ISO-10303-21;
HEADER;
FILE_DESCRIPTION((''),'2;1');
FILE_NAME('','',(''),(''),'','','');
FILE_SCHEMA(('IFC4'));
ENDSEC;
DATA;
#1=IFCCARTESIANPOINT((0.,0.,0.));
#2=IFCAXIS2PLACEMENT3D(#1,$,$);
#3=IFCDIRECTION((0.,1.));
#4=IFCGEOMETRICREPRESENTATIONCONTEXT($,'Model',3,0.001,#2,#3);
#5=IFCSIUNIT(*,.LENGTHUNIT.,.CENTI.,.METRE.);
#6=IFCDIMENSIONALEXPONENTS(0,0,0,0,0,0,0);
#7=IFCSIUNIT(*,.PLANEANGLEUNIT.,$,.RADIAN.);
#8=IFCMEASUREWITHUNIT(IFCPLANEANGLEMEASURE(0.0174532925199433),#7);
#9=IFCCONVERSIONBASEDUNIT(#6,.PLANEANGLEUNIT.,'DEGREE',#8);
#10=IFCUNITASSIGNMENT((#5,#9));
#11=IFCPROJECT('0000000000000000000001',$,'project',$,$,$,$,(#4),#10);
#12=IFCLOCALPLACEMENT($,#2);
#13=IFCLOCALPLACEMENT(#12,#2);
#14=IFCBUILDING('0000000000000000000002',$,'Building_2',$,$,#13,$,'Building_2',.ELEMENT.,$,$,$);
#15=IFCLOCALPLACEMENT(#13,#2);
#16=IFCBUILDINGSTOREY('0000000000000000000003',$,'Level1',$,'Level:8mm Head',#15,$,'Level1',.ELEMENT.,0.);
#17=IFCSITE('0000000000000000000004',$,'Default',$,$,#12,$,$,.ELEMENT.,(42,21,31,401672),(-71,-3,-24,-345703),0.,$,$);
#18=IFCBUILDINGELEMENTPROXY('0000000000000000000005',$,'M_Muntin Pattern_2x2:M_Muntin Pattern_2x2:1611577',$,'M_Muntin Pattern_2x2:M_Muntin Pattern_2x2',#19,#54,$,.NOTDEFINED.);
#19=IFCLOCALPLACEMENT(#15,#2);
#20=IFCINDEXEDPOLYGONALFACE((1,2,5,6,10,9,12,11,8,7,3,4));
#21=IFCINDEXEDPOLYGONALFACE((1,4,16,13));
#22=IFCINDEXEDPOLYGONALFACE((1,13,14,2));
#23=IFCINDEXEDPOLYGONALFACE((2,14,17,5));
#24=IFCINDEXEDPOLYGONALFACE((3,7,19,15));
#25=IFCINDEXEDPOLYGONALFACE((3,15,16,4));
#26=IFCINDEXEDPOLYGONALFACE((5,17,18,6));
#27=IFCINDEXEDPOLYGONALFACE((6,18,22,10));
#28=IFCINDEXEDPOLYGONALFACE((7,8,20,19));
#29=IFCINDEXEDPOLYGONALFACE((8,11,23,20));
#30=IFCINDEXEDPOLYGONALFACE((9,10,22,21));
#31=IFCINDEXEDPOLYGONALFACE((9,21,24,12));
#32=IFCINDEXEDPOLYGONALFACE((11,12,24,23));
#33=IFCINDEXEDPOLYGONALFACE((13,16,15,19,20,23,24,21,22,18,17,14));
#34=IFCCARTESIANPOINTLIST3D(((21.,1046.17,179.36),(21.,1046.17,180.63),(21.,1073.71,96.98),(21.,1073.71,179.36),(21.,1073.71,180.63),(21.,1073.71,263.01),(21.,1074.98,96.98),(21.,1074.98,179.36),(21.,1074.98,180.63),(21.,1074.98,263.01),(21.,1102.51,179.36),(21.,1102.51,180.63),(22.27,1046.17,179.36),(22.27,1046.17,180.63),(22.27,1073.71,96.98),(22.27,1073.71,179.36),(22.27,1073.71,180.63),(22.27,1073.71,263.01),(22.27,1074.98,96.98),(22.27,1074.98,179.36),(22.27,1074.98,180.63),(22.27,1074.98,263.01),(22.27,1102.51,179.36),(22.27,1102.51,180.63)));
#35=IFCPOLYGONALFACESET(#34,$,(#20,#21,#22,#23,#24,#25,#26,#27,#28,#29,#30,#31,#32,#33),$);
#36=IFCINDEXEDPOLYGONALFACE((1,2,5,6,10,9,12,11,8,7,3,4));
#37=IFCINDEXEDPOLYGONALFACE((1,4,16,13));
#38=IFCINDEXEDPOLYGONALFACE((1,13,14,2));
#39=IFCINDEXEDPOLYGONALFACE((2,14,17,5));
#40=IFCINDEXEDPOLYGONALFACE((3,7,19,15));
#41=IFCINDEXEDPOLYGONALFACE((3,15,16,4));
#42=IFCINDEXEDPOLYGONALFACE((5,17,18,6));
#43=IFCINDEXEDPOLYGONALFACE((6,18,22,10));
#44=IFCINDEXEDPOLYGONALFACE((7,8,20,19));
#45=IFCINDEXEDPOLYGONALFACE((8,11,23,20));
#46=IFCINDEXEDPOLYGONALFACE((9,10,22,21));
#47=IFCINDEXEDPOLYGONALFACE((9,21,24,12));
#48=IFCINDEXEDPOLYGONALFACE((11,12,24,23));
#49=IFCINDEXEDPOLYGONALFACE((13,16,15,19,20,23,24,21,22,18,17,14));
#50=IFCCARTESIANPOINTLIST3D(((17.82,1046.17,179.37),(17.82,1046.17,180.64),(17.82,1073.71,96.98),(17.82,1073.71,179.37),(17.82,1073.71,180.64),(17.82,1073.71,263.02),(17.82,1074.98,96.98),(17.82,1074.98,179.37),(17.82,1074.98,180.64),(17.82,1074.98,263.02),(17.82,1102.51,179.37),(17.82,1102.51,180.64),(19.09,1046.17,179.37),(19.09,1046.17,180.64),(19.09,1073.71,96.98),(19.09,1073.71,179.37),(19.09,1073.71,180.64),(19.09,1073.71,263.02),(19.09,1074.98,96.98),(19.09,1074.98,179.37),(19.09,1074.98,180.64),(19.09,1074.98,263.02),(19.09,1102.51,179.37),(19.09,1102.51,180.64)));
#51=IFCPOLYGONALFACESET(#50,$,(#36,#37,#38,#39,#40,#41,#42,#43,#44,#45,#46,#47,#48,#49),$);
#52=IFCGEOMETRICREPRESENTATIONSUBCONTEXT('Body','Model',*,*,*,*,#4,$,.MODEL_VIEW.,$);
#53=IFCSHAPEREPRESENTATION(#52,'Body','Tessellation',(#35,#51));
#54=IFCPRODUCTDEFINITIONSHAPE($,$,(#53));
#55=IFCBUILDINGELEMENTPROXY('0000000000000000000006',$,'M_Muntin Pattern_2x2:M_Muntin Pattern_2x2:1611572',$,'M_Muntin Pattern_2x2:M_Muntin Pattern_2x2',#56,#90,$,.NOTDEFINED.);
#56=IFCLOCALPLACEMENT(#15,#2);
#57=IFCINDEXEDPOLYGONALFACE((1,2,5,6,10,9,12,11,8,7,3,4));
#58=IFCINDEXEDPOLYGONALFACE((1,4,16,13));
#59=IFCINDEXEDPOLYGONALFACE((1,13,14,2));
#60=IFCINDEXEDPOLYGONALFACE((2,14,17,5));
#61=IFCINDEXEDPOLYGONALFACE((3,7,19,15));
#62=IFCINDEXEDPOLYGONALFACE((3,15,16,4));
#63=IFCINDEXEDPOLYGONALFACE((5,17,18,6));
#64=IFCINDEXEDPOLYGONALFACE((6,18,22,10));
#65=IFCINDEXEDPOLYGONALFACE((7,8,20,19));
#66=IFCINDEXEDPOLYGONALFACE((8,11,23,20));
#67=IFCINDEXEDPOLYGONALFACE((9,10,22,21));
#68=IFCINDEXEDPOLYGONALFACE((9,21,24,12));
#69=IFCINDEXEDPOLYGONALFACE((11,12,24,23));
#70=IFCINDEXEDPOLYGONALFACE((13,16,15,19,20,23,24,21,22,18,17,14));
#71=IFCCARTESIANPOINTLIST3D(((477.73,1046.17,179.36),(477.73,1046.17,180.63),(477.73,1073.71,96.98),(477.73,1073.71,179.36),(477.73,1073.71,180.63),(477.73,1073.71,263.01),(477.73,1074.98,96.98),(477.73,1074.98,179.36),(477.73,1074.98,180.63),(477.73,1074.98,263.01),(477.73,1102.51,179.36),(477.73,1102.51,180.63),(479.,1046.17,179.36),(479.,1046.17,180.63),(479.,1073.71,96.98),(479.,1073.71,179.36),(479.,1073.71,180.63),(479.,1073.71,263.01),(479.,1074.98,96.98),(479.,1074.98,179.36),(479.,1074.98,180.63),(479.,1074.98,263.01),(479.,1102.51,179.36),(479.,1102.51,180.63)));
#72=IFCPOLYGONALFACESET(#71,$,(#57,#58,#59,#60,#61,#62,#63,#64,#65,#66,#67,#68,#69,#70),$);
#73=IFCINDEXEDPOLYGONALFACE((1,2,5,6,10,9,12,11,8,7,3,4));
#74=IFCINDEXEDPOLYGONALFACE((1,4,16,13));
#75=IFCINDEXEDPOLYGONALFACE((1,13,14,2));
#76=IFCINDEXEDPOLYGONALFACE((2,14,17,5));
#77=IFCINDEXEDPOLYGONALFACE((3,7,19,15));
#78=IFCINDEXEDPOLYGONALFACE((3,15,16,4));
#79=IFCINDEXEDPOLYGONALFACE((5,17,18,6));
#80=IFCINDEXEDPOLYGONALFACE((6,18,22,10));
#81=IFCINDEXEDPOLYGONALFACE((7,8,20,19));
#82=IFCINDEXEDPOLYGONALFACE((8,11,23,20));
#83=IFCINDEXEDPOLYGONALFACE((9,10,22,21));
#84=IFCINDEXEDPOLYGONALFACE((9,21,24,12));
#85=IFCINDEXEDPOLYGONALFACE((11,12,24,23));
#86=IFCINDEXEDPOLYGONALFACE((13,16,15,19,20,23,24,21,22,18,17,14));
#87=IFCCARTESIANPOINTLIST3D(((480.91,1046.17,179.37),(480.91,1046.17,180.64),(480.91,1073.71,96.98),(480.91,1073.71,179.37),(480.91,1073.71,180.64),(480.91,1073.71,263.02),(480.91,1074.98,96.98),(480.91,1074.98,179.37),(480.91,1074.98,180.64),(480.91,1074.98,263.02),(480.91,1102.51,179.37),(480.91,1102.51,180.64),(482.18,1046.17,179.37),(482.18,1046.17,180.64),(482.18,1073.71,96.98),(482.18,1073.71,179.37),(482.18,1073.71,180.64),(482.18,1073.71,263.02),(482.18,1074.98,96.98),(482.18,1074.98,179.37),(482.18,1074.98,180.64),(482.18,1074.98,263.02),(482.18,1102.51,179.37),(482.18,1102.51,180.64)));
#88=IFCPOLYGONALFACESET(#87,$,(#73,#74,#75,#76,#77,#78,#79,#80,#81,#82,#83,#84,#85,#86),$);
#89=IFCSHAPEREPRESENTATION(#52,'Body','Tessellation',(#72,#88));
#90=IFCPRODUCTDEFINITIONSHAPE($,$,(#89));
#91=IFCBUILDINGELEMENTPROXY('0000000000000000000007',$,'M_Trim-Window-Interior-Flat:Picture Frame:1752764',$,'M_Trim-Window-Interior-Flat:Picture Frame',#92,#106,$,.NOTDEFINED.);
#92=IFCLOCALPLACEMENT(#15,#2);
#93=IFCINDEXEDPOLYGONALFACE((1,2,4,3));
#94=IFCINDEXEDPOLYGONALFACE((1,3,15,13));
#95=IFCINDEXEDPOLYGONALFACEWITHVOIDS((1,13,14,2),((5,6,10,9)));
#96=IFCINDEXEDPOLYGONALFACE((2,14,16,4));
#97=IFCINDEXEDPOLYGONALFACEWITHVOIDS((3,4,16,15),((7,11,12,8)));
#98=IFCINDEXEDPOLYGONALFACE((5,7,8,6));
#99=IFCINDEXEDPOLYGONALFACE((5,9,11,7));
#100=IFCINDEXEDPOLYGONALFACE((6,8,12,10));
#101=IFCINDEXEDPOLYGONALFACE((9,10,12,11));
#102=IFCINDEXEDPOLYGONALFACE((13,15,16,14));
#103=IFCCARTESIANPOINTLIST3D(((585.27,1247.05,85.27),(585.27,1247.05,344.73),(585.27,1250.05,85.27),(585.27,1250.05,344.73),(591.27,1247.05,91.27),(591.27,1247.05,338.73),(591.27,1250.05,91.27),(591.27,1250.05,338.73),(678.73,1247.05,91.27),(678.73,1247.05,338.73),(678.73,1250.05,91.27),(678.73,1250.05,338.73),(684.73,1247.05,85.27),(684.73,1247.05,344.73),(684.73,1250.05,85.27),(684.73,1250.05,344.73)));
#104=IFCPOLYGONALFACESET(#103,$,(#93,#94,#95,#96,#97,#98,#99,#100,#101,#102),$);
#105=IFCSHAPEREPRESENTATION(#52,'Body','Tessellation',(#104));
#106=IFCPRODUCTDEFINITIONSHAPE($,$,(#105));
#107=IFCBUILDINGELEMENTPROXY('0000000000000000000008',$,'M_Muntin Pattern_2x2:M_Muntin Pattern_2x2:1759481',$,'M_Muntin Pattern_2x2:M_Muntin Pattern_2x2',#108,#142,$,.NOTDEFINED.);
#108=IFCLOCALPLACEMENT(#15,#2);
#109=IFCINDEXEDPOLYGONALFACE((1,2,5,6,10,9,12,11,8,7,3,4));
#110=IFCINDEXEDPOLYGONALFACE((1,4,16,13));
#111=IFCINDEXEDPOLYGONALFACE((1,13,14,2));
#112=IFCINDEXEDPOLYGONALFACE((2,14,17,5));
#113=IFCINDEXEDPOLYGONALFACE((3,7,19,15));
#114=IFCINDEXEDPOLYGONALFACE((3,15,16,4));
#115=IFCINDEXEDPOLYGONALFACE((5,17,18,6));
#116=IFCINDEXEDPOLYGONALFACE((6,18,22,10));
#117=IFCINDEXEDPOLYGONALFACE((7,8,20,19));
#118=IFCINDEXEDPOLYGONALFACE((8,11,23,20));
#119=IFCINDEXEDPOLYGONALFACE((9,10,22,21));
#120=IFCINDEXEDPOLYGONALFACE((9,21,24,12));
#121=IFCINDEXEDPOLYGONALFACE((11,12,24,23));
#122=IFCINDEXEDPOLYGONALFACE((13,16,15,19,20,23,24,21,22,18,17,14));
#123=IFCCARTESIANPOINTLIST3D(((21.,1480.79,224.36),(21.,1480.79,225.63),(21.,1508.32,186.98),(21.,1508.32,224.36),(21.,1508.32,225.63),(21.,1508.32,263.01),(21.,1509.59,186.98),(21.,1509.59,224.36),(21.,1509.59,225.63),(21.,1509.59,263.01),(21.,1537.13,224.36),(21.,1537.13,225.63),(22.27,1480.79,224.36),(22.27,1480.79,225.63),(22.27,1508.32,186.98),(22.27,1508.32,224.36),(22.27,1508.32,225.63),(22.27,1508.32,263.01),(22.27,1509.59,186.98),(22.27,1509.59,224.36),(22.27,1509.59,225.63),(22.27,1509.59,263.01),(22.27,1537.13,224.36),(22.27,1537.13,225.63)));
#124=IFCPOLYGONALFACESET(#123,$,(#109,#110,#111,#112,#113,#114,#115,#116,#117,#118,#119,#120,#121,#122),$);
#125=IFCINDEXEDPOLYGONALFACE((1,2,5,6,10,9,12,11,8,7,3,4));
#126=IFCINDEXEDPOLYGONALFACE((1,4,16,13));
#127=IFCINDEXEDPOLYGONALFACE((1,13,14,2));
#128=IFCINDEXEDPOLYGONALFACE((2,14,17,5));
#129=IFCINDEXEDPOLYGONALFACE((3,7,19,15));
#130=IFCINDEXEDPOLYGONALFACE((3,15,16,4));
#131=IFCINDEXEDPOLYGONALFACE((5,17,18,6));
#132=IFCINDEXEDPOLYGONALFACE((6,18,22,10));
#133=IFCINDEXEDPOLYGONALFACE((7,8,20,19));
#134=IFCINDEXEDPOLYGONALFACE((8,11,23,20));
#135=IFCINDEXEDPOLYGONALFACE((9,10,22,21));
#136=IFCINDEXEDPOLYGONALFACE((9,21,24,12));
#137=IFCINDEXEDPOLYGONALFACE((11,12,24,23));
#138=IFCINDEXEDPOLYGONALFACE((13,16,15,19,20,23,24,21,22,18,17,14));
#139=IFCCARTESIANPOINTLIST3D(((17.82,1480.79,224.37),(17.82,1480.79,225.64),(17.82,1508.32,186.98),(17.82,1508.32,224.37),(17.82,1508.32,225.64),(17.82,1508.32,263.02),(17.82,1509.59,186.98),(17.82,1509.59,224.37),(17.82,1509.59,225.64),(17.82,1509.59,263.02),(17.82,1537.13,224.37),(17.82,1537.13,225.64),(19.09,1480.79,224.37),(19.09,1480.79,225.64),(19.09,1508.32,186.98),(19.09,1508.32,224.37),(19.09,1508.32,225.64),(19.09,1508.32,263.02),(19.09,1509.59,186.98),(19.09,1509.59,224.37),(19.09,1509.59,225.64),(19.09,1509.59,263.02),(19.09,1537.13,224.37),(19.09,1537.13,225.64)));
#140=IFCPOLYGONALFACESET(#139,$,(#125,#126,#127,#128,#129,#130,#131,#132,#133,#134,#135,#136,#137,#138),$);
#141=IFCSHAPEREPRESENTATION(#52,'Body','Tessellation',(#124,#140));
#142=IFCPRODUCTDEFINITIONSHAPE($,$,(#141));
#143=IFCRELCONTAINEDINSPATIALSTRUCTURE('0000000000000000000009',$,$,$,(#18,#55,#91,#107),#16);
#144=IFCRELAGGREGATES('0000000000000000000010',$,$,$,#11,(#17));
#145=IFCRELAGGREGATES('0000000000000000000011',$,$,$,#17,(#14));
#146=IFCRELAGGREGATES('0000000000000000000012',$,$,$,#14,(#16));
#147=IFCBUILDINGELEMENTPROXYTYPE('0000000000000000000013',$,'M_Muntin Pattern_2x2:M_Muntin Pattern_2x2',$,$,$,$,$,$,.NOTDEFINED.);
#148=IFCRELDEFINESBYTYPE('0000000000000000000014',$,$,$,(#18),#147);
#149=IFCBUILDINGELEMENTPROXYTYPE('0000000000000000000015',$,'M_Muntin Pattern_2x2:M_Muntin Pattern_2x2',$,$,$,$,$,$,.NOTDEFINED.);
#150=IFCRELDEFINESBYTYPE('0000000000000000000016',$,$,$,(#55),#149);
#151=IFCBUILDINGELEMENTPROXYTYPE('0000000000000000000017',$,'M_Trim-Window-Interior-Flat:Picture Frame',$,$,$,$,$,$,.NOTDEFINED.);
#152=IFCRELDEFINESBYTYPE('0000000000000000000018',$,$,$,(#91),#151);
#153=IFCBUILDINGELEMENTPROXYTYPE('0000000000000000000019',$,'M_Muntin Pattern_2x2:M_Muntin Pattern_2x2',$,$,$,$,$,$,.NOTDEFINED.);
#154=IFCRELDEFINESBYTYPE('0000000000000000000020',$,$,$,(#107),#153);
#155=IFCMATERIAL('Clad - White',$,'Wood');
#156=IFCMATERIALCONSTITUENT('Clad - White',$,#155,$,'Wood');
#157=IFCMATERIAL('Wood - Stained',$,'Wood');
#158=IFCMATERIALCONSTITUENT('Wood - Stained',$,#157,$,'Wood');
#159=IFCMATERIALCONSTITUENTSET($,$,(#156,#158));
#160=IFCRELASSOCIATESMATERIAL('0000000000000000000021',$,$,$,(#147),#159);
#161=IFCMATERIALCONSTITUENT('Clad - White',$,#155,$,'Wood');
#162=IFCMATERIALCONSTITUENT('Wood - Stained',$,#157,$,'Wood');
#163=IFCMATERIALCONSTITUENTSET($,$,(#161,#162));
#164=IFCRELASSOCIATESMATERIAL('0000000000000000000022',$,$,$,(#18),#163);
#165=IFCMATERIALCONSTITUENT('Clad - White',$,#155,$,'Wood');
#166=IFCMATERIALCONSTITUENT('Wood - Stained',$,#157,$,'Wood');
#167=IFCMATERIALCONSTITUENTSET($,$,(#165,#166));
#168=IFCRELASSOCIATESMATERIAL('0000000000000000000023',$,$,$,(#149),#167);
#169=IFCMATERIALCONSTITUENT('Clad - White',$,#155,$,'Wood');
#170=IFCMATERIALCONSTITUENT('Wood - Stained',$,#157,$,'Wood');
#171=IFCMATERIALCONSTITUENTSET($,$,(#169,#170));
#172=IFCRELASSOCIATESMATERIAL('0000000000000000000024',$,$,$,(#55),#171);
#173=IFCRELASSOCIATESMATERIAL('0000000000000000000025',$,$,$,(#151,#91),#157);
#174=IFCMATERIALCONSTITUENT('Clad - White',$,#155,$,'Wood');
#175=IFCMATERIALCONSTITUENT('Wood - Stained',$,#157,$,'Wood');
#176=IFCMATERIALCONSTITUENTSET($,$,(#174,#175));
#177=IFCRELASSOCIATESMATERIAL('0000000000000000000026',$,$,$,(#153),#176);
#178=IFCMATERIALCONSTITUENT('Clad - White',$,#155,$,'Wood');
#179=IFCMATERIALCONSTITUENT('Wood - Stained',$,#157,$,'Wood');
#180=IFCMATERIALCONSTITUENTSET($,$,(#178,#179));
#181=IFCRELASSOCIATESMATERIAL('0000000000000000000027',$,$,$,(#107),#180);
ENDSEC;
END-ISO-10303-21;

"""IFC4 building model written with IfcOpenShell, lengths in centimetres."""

from ifc_helpers import new_model, entity, si_unit, converted_unit, direction, frame, origin, place, context, subcontext, project, spatial, indexed_curve, outline, extrude, source, transform, mapped, material, constituent, constituent_set, type_object, type_shapes, element, save


model = new_model("IFC4")

# Units and contexts
model_context = context("Model", 3, precision=0.001, world=origin(), true_north=direction((0.0, 1.0)))
body_context = subcontext(model_context, "Body", "Model", "MODEL_VIEW")
ifc_project = project(units=[si_unit("LENGTHUNIT", "METRE", prefix="CENTI"), converted_unit("PLANEANGLEUNIT", "DEGREE", entity("IfcPlaneAngleMeasure", 0.0174532925199433), si_unit("PLANEANGLEUNIT", "RADIAN"), dimensions=[0, 0, 0, 0, 0, 0, 0])], contexts=[model_context])

# Site, building, storey
site_placement = place(None, origin())
site = spatial("IfcSite", under=ifc_project, at=site_placement, Name="Default", CompositionType="ELEMENT", RefLatitude=(42, 21, 31, 401672), RefLongitude=(-71, -3, -24, -345703), RefElevation=0.0)
building_placement = place(site_placement, origin())
building = spatial("IfcBuilding", under=site, at=building_placement, Name="Building_2", LongName="Building_2", CompositionType="ELEMENT")
storey_placement = place(building_placement, origin())
storey = spatial("IfcBuildingStorey", under=building, at=storey_placement, Name="Level1", ObjectType="Level:8mm Head", LongName="Level1", CompositionType="ELEMENT", Elevation=0.0)

# Building element proxies
ifc_material_1 = material(Name="Clad - White", Category="Wood")
ifc_constituent_1 = constituent(ifc_material_1, Name="Clad - White", Category="Wood")
ifc_material_2 = material(Name="Wood - Stained", Category="Wood")
ifc_constituent_2 = constituent(ifc_material_2, Name="Wood - Stained", Category="Wood")
ifc_constituent_set_1 = constituent_set(constituents=[ifc_constituent_1, ifc_constituent_2])
ifc_constituent_3 = constituent(ifc_material_1, Name="Clad - White", Category="Wood")
ifc_constituent_4 = constituent(ifc_material_2, Name="Wood - Stained", Category="Wood")
ifc_constituent_set_2 = constituent_set(constituents=[ifc_constituent_3, ifc_constituent_4])
building_element_proxy_type_1 = type_object("IfcBuildingElementProxyType", Name="M_Muntin Pattern_2x2:M_Muntin Pattern_2x2", PredefinedType="NOTDEFINED", material=ifc_constituent_set_2)
shared_shape_1 = source(origin(), body_context, "Body", "SweptSolid", [
    extrude(outline(indexed_curve([(0.64, -0.64), (83.01, -0.64), (83.01, 0.63), (0.64, 0.63), (0.64, 28.17), (-0.63, 28.17), (-0.63, 0.63), (-83.02, 0.63), (-83.02, -0.64), (-0.63, -0.64), (-0.63, -28.17), (0.64, -28.17), (0.64, -0.64)], self_intersect=False)), frame((0.0, 0.95, 83.01), z_axis=(0.0, 1.0, 0.0), x_axis=(0.0, 0.0, 1.0)), (0.0, 0.0, 1.0), 1.27),
    extrude(outline(indexed_curve([(0.64, -0.64), (83.02, -0.64), (83.02, 0.63), (0.64, 0.63), (0.64, 28.17), (-0.63, 28.17), (-0.63, 0.63), (-83.02, 0.63), (-83.02, -0.64), (-0.63, -0.64), (-0.63, -28.17), (0.64, -28.17), (0.64, -0.64)], self_intersect=False)), frame((0.0, -2.22, 83.02), z_axis=(0.0, 1.0, 0.0), x_axis=(0.0, 0.0, 1.0)), (0.0, 0.0, 1.0), 1.27),
])
type_shapes(building_element_proxy_type_1, [shared_shape_1])
proxy_1_placement = place(storey_placement, frame((20.05, 1074.34, 96.98), z_axis=(0.0, 0.0, 1.0), x_axis=(0.0, -1.0, 0.0)))
element("IfcBuildingElementProxy", 1, at=proxy_1_placement, inside=storey, type_object=building_element_proxy_type_1, material=ifc_constituent_set_1, Name="M_Muntin Pattern_2x2:M_Muntin Pattern_2x2:1611577", ObjectType="M_Muntin Pattern_2x2:M_Muntin Pattern_2x2", PredefinedType="NOTDEFINED", context=body_context, shape_type="MappedRepresentation", body=[
    mapped(shared_shape_1, transform((0.0, 0.0, 0.0), scale=1.0)),
])
ifc_constituent_5 = constituent(ifc_material_1, Name="Clad - White", Category="Wood")
ifc_constituent_6 = constituent(ifc_material_2, Name="Wood - Stained", Category="Wood")
ifc_constituent_set_3 = constituent_set(constituents=[ifc_constituent_5, ifc_constituent_6])
ifc_constituent_7 = constituent(ifc_material_1, Name="Clad - White", Category="Wood")
ifc_constituent_8 = constituent(ifc_material_2, Name="Wood - Stained", Category="Wood")
ifc_constituent_set_4 = constituent_set(constituents=[ifc_constituent_7, ifc_constituent_8])
building_element_proxy_type_2 = type_object("IfcBuildingElementProxyType", Name="M_Muntin Pattern_2x2:M_Muntin Pattern_2x2", PredefinedType="NOTDEFINED", material=ifc_constituent_set_4)
shared_shape_2 = source(origin(), body_context, "Body", "SweptSolid", [
    extrude(outline(indexed_curve([(0.64, -0.64), (83.01, -0.64), (83.01, 0.63), (0.64, 0.63), (0.64, 28.17), (-0.63, 28.17), (-0.63, 0.63), (-83.02, 0.63), (-83.02, -0.64), (-0.63, -0.64), (-0.63, -28.17), (0.64, -28.17), (0.64, -0.64)], self_intersect=False)), frame((0.0, -2.22, 83.01), z_axis=(0.0, 1.0, 0.0), x_axis=(0.0, 0.0, 1.0)), (0.0, 0.0, 1.0), 1.27),
    extrude(outline(indexed_curve([(0.64, -0.64), (83.02, -0.64), (83.02, 0.63), (0.64, 0.63), (0.64, 28.17), (-0.63, 28.17), (-0.63, 0.63), (-83.02, 0.63), (-83.02, -0.64), (-0.63, -0.64), (-0.63, -28.17), (0.64, -28.17), (0.64, -0.64)], self_intersect=False)), frame((0.0, 0.95, 83.02), z_axis=(0.0, 1.0, 0.0), x_axis=(0.0, 0.0, 1.0)), (0.0, 0.0, 1.0), 1.27),
])
type_shapes(building_element_proxy_type_2, [shared_shape_2])
proxy_2_placement = place(storey_placement, frame((479.95, 1074.34, 96.98), z_axis=(0.0, 0.0, 1.0), x_axis=(0.0, -1.0, 0.0)))
element("IfcBuildingElementProxy", 2, at=proxy_2_placement, inside=storey, type_object=building_element_proxy_type_2, material=ifc_constituent_set_3, Name="M_Muntin Pattern_2x2:M_Muntin Pattern_2x2:1611572", ObjectType="M_Muntin Pattern_2x2:M_Muntin Pattern_2x2", PredefinedType="NOTDEFINED", context=body_context, shape_type="MappedRepresentation", body=[
    mapped(shared_shape_2, transform((0.0, 0.0, 0.0), scale=1.0)),
])
building_element_proxy_type_3 = type_object("IfcBuildingElementProxyType", Name="M_Trim-Window-Interior-Flat:Picture Frame", PredefinedType="NOTDEFINED", material=ifc_material_2)
shared_shape_3 = source(origin(), body_context, "Body", "SweptSolid", [
    extrude(outline(indexed_curve([(-49.73, -129.73), (49.73, -129.73), (49.73, 129.73), (-49.73, 129.73), (-49.73, -129.73)], self_intersect=False), holes=[indexed_curve([(-43.73, -123.73), (-43.73, 123.73), (43.73, 123.73), (43.73, -123.73), (-43.73, -123.73)], self_intersect=False)]), frame((0.0, -125.0, 0.0), z_axis=(0.0, 0.0, 1.0), x_axis=(-1.0, 0.0, 0.0)), (0.0, 0.0, 1.0), 3.0),
])
type_shapes(building_element_proxy_type_3, [shared_shape_3])
proxy_3_placement = place(storey_placement, frame((635.0, 1250.05, 340.0), z_axis=(0.0, -1.0, 0.0), x_axis=(1.0, 0.0, 0.0)))
element("IfcBuildingElementProxy", 3, at=proxy_3_placement, inside=storey, type_object=building_element_proxy_type_3, material=ifc_material_2, Name="M_Trim-Window-Interior-Flat:Picture Frame:1752764", ObjectType="M_Trim-Window-Interior-Flat:Picture Frame", PredefinedType="NOTDEFINED", context=body_context, shape_type="MappedRepresentation", body=[
    mapped(shared_shape_3, transform((0.0, 0.0, 0.0), scale=1.0)),
])
ifc_constituent_9 = constituent(ifc_material_1, Name="Clad - White", Category="Wood")
ifc_constituent_10 = constituent(ifc_material_2, Name="Wood - Stained", Category="Wood")
ifc_constituent_set_5 = constituent_set(constituents=[ifc_constituent_9, ifc_constituent_10])
ifc_constituent_11 = constituent(ifc_material_1, Name="Clad - White", Category="Wood")
ifc_constituent_12 = constituent(ifc_material_2, Name="Wood - Stained", Category="Wood")
ifc_constituent_set_6 = constituent_set(constituents=[ifc_constituent_11, ifc_constituent_12])
building_element_proxy_type_4 = type_object("IfcBuildingElementProxyType", Name="M_Muntin Pattern_2x2:M_Muntin Pattern_2x2", PredefinedType="NOTDEFINED", material=ifc_constituent_set_6)
shared_shape_4 = source(origin(), body_context, "Body", "SweptSolid", [
    extrude(outline(indexed_curve([(0.64, -0.64), (38.01, -0.64), (38.01, 0.63), (0.64, 0.63), (0.64, 28.17), (-0.63, 28.17), (-0.63, 0.63), (-38.02, 0.63), (-38.02, -0.64), (-0.63, -0.64), (-0.63, -28.17), (0.64, -28.17), (0.64, -0.64)], self_intersect=False)), frame((0.0, -2.22, 38.01), z_axis=(0.0, 1.0, 0.0), x_axis=(0.0, 0.0, 1.0)), (0.0, 0.0, 1.0), 1.27),
    extrude(outline(indexed_curve([(0.64, -0.64), (38.02, -0.64), (38.02, 0.63), (0.64, 0.63), (0.64, 28.17), (-0.63, 28.17), (-0.63, 0.63), (-38.02, 0.63), (-38.02, -0.64), (-0.63, -0.64), (-0.63, -28.17), (0.64, -28.17), (0.64, -0.64)], self_intersect=False)), frame((0.0, 0.95, 38.02), z_axis=(0.0, 1.0, 0.0), x_axis=(0.0, 0.0, 1.0)), (0.0, 0.0, 1.0), 1.27),
])
type_shapes(building_element_proxy_type_4, [shared_shape_4])
proxy_4_placement = place(storey_placement, frame((20.05, 1508.96, 186.98), z_axis=(0.0, 0.0, 1.0), x_axis=(0.0, 1.0, 0.0)))
element("IfcBuildingElementProxy", 4, at=proxy_4_placement, inside=storey, type_object=building_element_proxy_type_4, material=ifc_constituent_set_5, Name="M_Muntin Pattern_2x2:M_Muntin Pattern_2x2:1759481", ObjectType="M_Muntin Pattern_2x2:M_Muntin Pattern_2x2", PredefinedType="NOTDEFINED", context=body_context, shape_type="MappedRepresentation", body=[
    mapped(shared_shape_4, transform((0.0, 0.0, 0.0), scale=1.0)),
])

save(model, "model.ifc")
